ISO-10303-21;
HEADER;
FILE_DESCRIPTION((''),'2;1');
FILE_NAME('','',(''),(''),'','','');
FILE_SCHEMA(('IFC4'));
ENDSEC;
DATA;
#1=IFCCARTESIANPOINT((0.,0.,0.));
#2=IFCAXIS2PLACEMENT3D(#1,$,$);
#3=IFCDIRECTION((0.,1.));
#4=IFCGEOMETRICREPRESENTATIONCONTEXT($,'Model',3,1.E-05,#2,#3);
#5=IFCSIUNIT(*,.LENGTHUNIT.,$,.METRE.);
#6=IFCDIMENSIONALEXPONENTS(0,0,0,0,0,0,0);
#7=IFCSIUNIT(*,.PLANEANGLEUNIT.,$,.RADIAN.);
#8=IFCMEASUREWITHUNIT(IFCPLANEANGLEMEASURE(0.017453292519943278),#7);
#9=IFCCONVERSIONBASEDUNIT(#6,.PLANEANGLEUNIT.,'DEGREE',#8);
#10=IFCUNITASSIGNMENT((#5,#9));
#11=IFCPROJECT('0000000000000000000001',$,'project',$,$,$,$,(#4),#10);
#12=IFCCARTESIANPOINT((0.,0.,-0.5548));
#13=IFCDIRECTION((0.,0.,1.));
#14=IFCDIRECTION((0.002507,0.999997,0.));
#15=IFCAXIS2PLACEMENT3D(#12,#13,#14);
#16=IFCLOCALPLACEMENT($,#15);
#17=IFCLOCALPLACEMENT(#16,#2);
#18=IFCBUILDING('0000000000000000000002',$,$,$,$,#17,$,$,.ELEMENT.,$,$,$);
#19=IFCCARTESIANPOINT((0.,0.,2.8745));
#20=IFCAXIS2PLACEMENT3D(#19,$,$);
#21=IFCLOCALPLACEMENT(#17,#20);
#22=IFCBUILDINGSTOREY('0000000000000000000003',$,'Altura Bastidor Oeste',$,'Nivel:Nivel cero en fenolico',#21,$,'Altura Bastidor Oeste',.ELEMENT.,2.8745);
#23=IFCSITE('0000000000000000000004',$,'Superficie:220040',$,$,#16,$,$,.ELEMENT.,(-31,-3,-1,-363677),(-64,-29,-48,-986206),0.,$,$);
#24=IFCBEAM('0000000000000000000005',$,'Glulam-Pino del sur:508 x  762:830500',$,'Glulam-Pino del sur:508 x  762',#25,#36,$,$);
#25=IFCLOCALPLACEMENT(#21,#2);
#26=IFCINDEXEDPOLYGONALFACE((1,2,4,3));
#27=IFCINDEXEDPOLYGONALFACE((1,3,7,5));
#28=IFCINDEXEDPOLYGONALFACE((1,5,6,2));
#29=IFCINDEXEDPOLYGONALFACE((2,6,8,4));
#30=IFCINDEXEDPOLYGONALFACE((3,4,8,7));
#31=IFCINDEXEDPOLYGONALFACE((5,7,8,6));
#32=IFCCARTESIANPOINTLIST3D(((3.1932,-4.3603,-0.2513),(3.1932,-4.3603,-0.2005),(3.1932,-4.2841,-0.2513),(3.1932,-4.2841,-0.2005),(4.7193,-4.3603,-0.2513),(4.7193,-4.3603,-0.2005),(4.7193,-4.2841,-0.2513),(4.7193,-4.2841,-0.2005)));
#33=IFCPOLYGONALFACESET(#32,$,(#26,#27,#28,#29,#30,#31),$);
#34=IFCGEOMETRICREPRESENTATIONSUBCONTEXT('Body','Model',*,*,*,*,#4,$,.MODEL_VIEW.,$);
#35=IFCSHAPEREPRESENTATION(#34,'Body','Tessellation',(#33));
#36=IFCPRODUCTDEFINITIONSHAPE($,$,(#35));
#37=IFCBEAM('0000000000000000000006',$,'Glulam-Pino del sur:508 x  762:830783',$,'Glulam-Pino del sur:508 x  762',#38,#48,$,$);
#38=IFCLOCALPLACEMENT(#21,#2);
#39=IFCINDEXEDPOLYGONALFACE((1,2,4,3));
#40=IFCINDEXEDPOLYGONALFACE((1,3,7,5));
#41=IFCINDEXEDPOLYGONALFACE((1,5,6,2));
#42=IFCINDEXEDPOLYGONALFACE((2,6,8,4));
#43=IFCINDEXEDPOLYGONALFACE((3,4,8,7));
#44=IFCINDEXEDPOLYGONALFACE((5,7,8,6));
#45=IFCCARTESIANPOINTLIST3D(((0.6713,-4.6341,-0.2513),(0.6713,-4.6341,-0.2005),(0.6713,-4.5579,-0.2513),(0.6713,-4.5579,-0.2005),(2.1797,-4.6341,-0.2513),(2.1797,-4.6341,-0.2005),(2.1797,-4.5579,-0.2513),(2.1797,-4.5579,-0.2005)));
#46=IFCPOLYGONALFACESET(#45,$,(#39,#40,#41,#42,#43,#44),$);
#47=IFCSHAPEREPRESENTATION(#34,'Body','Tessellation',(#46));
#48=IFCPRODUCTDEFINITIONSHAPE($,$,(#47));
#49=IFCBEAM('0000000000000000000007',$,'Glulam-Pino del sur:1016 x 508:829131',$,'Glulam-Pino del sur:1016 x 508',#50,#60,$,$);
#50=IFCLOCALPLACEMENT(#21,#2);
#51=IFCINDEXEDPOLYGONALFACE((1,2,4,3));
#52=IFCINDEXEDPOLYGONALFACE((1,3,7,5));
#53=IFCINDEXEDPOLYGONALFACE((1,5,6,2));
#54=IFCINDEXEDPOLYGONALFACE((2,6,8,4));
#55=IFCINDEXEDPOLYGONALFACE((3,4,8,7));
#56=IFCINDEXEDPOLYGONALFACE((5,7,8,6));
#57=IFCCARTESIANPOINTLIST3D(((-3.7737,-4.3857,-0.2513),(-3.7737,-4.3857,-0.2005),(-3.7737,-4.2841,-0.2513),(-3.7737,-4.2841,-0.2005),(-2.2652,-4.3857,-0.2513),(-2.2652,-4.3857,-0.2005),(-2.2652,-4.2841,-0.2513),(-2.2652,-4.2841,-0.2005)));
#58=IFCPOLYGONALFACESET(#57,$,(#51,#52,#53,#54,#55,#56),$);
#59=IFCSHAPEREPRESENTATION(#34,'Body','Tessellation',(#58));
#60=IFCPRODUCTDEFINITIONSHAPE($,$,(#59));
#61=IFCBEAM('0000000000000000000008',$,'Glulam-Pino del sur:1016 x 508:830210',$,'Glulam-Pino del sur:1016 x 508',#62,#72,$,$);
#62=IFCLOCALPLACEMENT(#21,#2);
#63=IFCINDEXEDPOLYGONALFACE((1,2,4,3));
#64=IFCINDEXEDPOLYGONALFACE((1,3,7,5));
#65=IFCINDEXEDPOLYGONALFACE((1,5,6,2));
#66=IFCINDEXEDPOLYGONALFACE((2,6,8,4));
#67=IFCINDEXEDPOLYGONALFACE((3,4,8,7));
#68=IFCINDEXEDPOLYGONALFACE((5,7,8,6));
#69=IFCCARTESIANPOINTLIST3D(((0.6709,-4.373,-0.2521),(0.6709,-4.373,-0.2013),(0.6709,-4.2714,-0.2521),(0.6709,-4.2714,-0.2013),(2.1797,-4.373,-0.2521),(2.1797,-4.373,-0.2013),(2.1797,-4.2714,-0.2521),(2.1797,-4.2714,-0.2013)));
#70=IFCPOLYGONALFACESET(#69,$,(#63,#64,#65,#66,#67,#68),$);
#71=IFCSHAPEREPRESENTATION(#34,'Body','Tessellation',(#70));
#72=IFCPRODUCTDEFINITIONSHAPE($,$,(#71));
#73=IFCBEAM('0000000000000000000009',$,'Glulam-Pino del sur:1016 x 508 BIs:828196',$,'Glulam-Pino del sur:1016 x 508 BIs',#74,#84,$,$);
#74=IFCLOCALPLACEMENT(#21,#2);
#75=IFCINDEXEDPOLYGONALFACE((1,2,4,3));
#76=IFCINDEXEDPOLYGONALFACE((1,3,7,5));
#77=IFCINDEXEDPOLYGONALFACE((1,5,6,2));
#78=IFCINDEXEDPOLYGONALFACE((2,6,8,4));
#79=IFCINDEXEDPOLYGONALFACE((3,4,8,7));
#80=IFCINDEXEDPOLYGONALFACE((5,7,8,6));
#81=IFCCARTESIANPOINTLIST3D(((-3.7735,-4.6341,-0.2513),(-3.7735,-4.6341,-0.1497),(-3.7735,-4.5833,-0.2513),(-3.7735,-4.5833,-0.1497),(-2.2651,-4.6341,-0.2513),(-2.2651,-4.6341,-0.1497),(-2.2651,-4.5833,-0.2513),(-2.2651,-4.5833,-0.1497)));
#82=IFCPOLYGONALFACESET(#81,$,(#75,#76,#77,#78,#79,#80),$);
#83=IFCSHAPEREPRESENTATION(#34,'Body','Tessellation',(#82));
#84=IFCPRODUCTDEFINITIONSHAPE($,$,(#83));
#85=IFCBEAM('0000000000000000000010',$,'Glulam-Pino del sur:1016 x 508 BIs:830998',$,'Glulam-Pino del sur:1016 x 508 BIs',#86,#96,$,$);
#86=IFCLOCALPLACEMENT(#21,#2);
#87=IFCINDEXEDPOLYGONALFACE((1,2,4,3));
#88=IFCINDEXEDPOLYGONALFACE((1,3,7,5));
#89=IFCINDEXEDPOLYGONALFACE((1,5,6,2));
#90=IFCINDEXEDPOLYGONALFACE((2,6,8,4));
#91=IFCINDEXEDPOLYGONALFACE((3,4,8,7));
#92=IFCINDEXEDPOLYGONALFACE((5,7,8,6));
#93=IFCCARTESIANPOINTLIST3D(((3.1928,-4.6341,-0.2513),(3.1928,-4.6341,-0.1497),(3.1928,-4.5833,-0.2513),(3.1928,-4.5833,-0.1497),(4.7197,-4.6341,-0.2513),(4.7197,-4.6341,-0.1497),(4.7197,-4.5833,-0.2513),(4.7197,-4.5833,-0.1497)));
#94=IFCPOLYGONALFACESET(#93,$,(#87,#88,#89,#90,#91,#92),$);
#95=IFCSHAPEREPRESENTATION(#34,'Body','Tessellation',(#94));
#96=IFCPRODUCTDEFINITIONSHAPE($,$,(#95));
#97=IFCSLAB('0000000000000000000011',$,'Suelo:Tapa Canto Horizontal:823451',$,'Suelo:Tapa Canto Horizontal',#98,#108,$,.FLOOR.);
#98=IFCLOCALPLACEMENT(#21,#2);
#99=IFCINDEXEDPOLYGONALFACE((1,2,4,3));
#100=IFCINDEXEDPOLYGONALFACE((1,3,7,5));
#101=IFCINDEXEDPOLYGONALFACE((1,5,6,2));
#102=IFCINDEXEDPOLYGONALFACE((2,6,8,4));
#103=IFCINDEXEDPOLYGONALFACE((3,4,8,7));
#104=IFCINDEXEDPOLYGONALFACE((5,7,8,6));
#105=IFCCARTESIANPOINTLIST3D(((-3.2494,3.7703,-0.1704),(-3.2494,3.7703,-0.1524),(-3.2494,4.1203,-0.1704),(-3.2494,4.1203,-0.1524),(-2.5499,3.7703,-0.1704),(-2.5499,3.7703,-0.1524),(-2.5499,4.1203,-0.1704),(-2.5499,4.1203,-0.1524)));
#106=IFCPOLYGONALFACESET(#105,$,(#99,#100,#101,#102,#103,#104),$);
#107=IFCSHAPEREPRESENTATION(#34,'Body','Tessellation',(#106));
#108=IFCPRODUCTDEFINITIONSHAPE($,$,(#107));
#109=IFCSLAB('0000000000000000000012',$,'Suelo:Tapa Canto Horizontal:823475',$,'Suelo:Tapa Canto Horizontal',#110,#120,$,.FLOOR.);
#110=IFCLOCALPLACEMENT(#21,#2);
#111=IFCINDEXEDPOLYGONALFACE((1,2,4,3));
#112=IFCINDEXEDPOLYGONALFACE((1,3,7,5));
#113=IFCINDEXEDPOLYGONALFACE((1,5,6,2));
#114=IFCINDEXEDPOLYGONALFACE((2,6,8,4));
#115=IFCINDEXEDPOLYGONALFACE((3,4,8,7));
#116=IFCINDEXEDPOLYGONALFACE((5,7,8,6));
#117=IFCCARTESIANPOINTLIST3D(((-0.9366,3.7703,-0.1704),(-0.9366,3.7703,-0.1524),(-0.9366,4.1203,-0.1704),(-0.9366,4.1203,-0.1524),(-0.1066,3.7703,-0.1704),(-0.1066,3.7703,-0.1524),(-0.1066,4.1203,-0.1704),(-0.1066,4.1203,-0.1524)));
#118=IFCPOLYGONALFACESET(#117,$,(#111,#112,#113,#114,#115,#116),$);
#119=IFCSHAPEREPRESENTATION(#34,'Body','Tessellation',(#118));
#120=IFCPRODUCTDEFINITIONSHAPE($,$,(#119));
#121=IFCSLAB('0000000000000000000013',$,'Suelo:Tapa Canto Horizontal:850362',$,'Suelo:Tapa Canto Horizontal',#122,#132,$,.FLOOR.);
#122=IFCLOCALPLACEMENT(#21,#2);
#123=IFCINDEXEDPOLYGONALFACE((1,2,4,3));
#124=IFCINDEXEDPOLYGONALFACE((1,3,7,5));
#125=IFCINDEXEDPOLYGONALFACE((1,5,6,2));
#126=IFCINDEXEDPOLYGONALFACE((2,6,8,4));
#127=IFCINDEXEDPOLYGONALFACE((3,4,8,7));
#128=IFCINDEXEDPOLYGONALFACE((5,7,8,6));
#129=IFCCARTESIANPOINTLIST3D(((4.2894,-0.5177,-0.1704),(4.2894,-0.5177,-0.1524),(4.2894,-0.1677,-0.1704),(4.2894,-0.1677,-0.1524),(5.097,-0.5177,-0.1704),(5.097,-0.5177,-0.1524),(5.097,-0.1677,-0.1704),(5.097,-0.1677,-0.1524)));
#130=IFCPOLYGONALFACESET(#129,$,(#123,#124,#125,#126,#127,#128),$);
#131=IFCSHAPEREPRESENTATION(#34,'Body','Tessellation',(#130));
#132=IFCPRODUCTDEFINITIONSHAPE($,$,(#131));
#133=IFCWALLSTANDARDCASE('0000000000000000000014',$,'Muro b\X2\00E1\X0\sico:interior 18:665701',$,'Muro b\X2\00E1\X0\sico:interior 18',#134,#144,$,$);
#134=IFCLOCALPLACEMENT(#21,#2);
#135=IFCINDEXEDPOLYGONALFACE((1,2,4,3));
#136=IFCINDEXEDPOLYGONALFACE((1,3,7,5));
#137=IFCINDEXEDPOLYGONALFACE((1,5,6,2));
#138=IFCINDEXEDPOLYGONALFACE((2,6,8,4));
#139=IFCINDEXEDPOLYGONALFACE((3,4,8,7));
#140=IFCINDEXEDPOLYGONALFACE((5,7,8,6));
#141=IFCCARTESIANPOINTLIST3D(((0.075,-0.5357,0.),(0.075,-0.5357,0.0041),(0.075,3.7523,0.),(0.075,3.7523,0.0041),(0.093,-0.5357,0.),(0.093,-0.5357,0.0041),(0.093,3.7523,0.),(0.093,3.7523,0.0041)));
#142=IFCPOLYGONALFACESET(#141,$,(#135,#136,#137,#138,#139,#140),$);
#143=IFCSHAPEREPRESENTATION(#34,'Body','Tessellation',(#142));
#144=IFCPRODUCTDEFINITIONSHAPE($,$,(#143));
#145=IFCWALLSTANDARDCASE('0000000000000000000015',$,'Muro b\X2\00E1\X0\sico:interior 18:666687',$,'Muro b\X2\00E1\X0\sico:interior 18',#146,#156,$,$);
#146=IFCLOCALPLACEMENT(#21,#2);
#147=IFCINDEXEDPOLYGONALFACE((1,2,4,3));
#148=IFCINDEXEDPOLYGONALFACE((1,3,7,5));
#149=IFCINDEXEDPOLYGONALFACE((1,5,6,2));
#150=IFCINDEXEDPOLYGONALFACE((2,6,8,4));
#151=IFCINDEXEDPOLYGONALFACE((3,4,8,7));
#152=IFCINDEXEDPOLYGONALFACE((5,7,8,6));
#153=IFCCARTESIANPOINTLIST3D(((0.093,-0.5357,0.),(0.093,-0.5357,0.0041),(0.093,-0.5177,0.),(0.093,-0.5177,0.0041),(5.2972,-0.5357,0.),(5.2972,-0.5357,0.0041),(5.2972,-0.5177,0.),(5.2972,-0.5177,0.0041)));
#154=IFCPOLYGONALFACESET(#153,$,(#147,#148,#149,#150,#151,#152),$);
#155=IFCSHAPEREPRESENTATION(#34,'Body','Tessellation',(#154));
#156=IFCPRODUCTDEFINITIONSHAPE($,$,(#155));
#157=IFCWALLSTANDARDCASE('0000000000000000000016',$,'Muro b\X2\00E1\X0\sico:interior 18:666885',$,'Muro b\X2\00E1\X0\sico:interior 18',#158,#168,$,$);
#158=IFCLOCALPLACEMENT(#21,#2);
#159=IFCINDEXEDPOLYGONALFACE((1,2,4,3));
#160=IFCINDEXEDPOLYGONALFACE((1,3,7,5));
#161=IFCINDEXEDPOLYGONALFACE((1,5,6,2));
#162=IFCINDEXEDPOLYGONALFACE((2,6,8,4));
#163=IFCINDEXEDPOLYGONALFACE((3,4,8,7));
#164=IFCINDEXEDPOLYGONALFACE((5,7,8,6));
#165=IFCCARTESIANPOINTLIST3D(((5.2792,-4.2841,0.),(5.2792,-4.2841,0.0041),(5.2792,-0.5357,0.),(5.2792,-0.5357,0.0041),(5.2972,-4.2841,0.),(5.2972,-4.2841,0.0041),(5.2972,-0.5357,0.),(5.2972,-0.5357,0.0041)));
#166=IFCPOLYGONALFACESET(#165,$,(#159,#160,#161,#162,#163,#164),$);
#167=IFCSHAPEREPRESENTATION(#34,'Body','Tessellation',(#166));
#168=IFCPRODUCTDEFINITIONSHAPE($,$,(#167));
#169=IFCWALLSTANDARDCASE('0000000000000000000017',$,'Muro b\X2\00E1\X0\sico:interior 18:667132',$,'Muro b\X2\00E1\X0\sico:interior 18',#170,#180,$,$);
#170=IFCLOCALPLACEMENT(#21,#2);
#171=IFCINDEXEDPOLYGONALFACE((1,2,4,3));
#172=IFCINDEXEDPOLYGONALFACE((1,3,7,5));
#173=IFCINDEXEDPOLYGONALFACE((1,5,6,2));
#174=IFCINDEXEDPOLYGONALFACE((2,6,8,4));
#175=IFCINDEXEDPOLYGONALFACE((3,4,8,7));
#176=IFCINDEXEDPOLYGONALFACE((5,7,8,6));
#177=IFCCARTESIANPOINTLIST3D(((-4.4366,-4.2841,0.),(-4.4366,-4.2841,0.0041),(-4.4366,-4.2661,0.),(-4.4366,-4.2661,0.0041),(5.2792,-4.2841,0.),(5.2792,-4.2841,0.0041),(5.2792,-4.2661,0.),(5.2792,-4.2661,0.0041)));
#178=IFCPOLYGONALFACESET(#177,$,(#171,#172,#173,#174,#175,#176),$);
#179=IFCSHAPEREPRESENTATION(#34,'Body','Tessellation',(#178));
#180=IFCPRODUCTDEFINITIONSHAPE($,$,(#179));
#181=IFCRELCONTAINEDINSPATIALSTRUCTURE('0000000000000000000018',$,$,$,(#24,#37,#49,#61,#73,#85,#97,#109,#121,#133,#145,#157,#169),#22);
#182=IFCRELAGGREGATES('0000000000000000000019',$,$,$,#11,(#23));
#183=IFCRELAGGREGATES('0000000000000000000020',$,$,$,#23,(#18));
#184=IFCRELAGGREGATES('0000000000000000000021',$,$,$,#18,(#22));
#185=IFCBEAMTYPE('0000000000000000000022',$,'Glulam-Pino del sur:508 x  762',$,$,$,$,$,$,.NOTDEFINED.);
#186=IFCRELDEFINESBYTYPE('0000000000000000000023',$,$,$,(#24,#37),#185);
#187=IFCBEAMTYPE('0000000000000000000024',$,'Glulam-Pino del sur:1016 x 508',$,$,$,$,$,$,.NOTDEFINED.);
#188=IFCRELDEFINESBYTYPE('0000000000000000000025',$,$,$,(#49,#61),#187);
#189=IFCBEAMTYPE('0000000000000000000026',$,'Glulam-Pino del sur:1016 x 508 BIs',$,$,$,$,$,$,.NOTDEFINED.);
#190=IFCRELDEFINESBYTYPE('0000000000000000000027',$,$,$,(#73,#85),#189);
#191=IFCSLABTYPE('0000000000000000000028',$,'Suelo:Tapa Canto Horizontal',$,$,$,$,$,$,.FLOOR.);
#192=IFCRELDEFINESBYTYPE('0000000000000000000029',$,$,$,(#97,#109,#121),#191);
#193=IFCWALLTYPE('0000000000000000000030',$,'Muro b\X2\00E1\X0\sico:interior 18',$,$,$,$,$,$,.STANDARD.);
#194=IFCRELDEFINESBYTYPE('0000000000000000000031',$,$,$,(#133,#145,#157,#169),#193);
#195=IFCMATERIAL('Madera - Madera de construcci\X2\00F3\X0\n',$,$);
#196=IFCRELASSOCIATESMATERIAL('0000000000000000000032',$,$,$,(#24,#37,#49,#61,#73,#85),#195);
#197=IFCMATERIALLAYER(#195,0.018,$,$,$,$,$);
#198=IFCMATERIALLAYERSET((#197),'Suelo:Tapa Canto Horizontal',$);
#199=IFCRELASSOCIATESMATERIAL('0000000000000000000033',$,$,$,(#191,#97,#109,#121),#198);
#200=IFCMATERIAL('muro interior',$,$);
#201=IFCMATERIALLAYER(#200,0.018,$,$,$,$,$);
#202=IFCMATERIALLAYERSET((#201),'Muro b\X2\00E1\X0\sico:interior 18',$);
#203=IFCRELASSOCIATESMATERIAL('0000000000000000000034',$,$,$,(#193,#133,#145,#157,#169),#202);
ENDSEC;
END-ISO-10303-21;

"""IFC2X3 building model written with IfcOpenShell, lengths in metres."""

from ifc_helpers import new_model, entity, si_unit, converted_unit, direction, frame, frame_2d, origin, place, context, subcontext, project, spatial, rectangle, extrude, clip, halfspace, material, layer, layer_set, layer_usage, type_object, element, save


model = new_model("IFC2X3")

# Units and contexts
model_context = context("Model", 3, precision=1e-05, world=origin(), true_north=direction((0.0, 1.0)))
body_context = subcontext(model_context, "Body", "Model", "MODEL_VIEW")
ifc_project = project(units=[si_unit("LENGTHUNIT", "METRE"), converted_unit("PLANEANGLEUNIT", "DEGREE", entity("IfcPlaneAngleMeasure", 0.017453292519943278), si_unit("PLANEANGLEUNIT", "RADIAN"), dimensions=[0, 0, 0, 0, 0, 0, 0])], contexts=[model_context])

# Site, building, storey
site_placement = place(None, frame((0.0, 0.0, -0.5548), z_axis=(0.0, 0.0, 1.0), x_axis=(0.002507, 0.999997, 0.0)))
site = spatial("IfcSite", under=ifc_project, at=site_placement, Name="Superficie:220040", CompositionType="ELEMENT", RefLatitude=(-31, -3, -1, -363677), RefLongitude=(-64, -29, -48, -986206), RefElevation=0.0)
building_placement = place(site_placement, origin())
building = spatial("IfcBuilding", under=site, at=building_placement, CompositionType="ELEMENT")
storey_placement = place(building_placement, frame((0.0, 0.0, 2.8745)))
storey = spatial("IfcBuildingStorey", under=building, at=storey_placement, Name="Altura Bastidor Oeste", ObjectType="Nivel:Nivel cero en fenolico", LongName="Altura Bastidor Oeste", CompositionType="ELEMENT", Elevation=2.8745)

# Shared definitions
ifc_material_1 = material(Name="Madera - Madera de construcción")

# Beams
beam_type_1 = type_object("IfcBeamType", Name="Glulam-Pino del sur:508 x  762", PredefinedType="NOTDEFINED")
beam_1_placement = place(storey_placement, frame((4.241, -4.3222, -0.2005)))
element("IfcBeam", 1, at=beam_1_placement, inside=storey, type_object=beam_type_1, material=ifc_material_1, Name="Glulam-Pino del sur:508 x  762:830500", ObjectType="Glulam-Pino del sur:508 x  762", context=body_context, shape_type="SweptSolid", body=[
    extrude(rectangle(XDim=0.0508, YDim=0.0762, at=frame_2d((0.0, 0.0), x_axis=(1.0, 0.0))), frame((-1.0478, 0.0, -0.0254), z_axis=(1.0, 0.0, 0.0), x_axis=(0.0, 0.0, -1.0)), (0.0, 0.0, 1.0), 1.5261),
])
beam_2_placement = place(storey_placement, frame((1.7506, -4.596, -0.2005)))
element("IfcBeam", 2, at=beam_2_placement, inside=storey, type_object=beam_type_1, material=ifc_material_1, Name="Glulam-Pino del sur:508 x  762:830783", ObjectType="Glulam-Pino del sur:508 x  762", context=body_context, shape_type="SweptSolid", body=[
    extrude(rectangle(XDim=0.0508, YDim=0.0762, at=frame_2d((0.0, 0.0), x_axis=(1.0, 0.0))), frame((-1.0793, 0.0, -0.0254), z_axis=(1.0, 0.0, 0.0), x_axis=(0.0, 0.0, -1.0)), (0.0, 0.0, 1.0), 1.5084),
])
beam_type_2 = type_object("IfcBeamType", Name="Glulam-Pino del sur:1016 x 508", PredefinedType="NOTDEFINED")
beam_3_placement = place(storey_placement, frame((2.6931, -4.3349, -0.2005)))
element("IfcBeam", 3, at=beam_3_placement, inside=storey, type_object=beam_type_2, material=ifc_material_1, Name="Glulam-Pino del sur:1016 x 508:829131", ObjectType="Glulam-Pino del sur:1016 x 508", context=body_context, shape_type="SweptSolid", body=[
    extrude(rectangle(XDim=0.0508, YDim=0.1016, at=frame_2d((0.0, 0.0), x_axis=(1.0, 0.0))), frame((-6.4668, 0.0, -0.0254), z_axis=(1.0, 0.0, 0.0), x_axis=(0.0, 0.0, -1.0)), (0.0, 0.0, 1.0), 1.5084),
])
beam_4_placement = place(storey_placement, frame((1.7044, -4.3222, -0.2013)))
element("IfcBeam", 4, at=beam_4_placement, inside=storey, type_object=beam_type_2, material=ifc_material_1, Name="Glulam-Pino del sur:1016 x 508:830210", ObjectType="Glulam-Pino del sur:1016 x 508", context=body_context, shape_type="SweptSolid", body=[
    extrude(rectangle(XDim=0.0508, YDim=0.1016, at=frame_2d((0.0, 0.0), x_axis=(1.0, 0.0))), frame((-1.0335, 0.0, -0.0254), z_axis=(1.0, 0.0, 0.0), x_axis=(0.0, 0.0, -1.0)), (0.0, 0.0, 1.0), 1.5087),
])
beam_type_3 = type_object("IfcBeamType", Name="Glulam-Pino del sur:1016 x 508 BIs", PredefinedType="NOTDEFINED")
beam_5_placement = place(storey_placement, frame((2.6863, -4.6087, -0.1497)))
element("IfcBeam", 5, at=beam_5_placement, inside=storey, type_object=beam_type_3, material=ifc_material_1, Name="Glulam-Pino del sur:1016 x 508 BIs:828196", ObjectType="Glulam-Pino del sur:1016 x 508 BIs", context=body_context, shape_type="SweptSolid", body=[
    extrude(rectangle(XDim=0.1016, YDim=0.0508, at=frame_2d((0.0, 0.0), x_axis=(1.0, 0.0))), frame((-6.4598, 0.0, -0.0508), z_axis=(1.0, 0.0, 0.0), x_axis=(0.0, 0.0, -1.0)), (0.0, 0.0, 1.0), 1.5084),
])
beam_6_placement = place(storey_placement, frame((4.241, -4.6087, -0.1497)))
element("IfcBeam", 6, at=beam_6_placement, inside=storey, type_object=beam_type_3, material=ifc_material_1, Name="Glulam-Pino del sur:1016 x 508 BIs:830998", ObjectType="Glulam-Pino del sur:1016 x 508 BIs", context=body_context, shape_type="SweptSolid", body=[
    extrude(rectangle(XDim=0.1016, YDim=0.0508, at=frame_2d((0.0, 0.0), x_axis=(1.0, 0.0))), frame((-1.0482, 0.0, -0.0508), z_axis=(1.0, 0.0, 0.0), x_axis=(0.0, 0.0, -1.0)), (0.0, 0.0, 1.0), 1.5269),
])

# Slabs
ifc_layer_1 = layer(ifc_material_1, 0.018)
ifc_layer_set_1 = layer_set([ifc_layer_1], Name="Suelo:Tapa Canto Horizontal")
ifc_layer_usage_1 = layer_usage(ifc_layer_set_1, "AXIS3", "POSITIVE", 0.0)
slab_type = type_object("IfcSlabType", Name="Suelo:Tapa Canto Horizontal", PredefinedType="FLOOR", material=ifc_layer_set_1)
slab_1_placement = place(storey_placement, origin())
element("IfcSlab", 7, at=slab_1_placement, inside=storey, type_object=slab_type, material=ifc_layer_usage_1, Name="Suelo:Tapa Canto Horizontal:823451", ObjectType="Suelo:Tapa Canto Horizontal", PredefinedType="FLOOR", context=body_context, shape_type="SweptSolid", body=[
    extrude(rectangle(XDim=0.35, YDim=0.6996, at=frame_2d((0.0, 0.0), x_axis=(1.0, 0.0))), frame((-2.8996, 3.9453, -0.1524), z_axis=(0.0, 0.0, -1.0), x_axis=(0.0, 1.0, 0.0)), (0.0, 0.0, 1.0), 0.018),
])
slab_2_placement = place(storey_placement, origin())
element("IfcSlab", 8, at=slab_2_placement, inside=storey, type_object=slab_type, material=ifc_layer_usage_1, Name="Suelo:Tapa Canto Horizontal:823475", ObjectType="Suelo:Tapa Canto Horizontal", PredefinedType="FLOOR", context=body_context, shape_type="SweptSolid", body=[
    extrude(rectangle(XDim=0.35, YDim=0.83, at=frame_2d((0.0, 0.0), x_axis=(1.0, 0.0))), frame((-0.5216, 3.9453, -0.1524), z_axis=(0.0, 0.0, -1.0), x_axis=(0.0, 1.0, 0.0)), (0.0, 0.0, 1.0), 0.018),
])
slab_3_placement = place(storey_placement, origin())
element("IfcSlab", 9, at=slab_3_placement, inside=storey, type_object=slab_type, material=ifc_layer_usage_1, Name="Suelo:Tapa Canto Horizontal:850362", ObjectType="Suelo:Tapa Canto Horizontal", PredefinedType="FLOOR", context=body_context, shape_type="SweptSolid", body=[
    extrude(rectangle(XDim=0.35, YDim=0.8076, at=frame_2d((0.0, 0.0), x_axis=(1.0, 0.0))), frame((4.6932, -0.3427, -0.1524), z_axis=(0.0, 0.0, -1.0), x_axis=(0.0, 1.0, 0.0)), (0.0, 0.0, 1.0), 0.018),
])

# Walls
ifc_material_2 = material(Name="muro interior")
ifc_layer_2 = layer(ifc_material_2, 0.018)
ifc_layer_set_2 = layer_set([ifc_layer_2], Name="Muro básico:interior 18")
ifc_layer_usage_2 = layer_usage(ifc_layer_set_2, "AXIS2", "NEGATIVE", 0.009)
wall_type_1 = type_object("IfcWallType", Name="Muro básico:interior 18", PredefinedType="STANDARD", material=ifc_layer_set_2)
wall_1_placement = place(storey_placement, frame((0.084, 3.7523, 0.0), z_axis=(0.0, 0.0, 1.0), x_axis=(0.0, -1.0, 0.0)))
element("IfcWallStandardCase", 10, at=wall_1_placement, inside=storey, type_object=wall_type_1, material=ifc_layer_usage_2, Name="Muro básico:interior 18:665701", ObjectType="Muro básico:interior 18", context=body_context, shape_type="Clipping", body=[
    clip(extrude(rectangle(XDim=4.288, YDim=0.018, at=frame_2d((2.144, 0.0), x_axis=(-1.0, 0.0))), origin(), (0.0, 0.0, 1.0), 0.0041), halfspace(frame((0.0, 0.0, -2.8237)), True)),
])
wall_2_placement = place(storey_placement, frame((0.093, -0.5267, 0.0)))
element("IfcWallStandardCase", 11, at=wall_2_placement, inside=storey, type_object=wall_type_1, material=ifc_layer_usage_2, Name="Muro básico:interior 18:666687", ObjectType="Muro básico:interior 18", context=body_context, shape_type="Clipping", body=[
    clip(extrude(rectangle(XDim=5.2042, YDim=0.018, at=frame_2d((2.6021, 0.0), x_axis=(-1.0, 0.0))), origin(), (0.0, 0.0, 1.0), 0.0041), halfspace(frame((0.0, 0.0, -2.8237)), True)),
])
wall_3_placement = place(storey_placement, frame((5.2882, -0.5357, 0.0), z_axis=(0.0, 0.0, 1.0), x_axis=(0.0, -1.0, 0.0)))
element("IfcWallStandardCase", 12, at=wall_3_placement, inside=storey, type_object=wall_type_1, material=ifc_layer_usage_2, Name="Muro básico:interior 18:666885", ObjectType="Muro básico:interior 18", context=body_context, shape_type="Clipping", body=[
    clip(extrude(rectangle(XDim=3.7484, YDim=0.018, at=frame_2d((1.8742, 0.0), x_axis=(-1.0, 0.0))), origin(), (0.0, 0.0, 1.0), 0.0041), halfspace(frame((0.0, 0.0, -2.8237)), True)),
])
wall_4_placement = place(storey_placement, frame((5.2792, -4.2751, 0.0), z_axis=(0.0, 0.0, 1.0), x_axis=(-1.0, 0.0, 0.0)))
element("IfcWallStandardCase", 13, at=wall_4_placement, inside=storey, type_object=wall_type_1, material=ifc_layer_usage_2, Name="Muro básico:interior 18:667132", ObjectType="Muro básico:interior 18", context=body_context, shape_type="Clipping", body=[
    clip(extrude(rectangle(XDim=9.7158, YDim=0.018, at=frame_2d((4.8579, 0.0), x_axis=(-1.0, 0.0))), origin(), (0.0, 0.0, 1.0), 0.0041), halfspace(frame((0.0, 0.0, -2.8237)), True)),
])

save(model, "model.ifc")
